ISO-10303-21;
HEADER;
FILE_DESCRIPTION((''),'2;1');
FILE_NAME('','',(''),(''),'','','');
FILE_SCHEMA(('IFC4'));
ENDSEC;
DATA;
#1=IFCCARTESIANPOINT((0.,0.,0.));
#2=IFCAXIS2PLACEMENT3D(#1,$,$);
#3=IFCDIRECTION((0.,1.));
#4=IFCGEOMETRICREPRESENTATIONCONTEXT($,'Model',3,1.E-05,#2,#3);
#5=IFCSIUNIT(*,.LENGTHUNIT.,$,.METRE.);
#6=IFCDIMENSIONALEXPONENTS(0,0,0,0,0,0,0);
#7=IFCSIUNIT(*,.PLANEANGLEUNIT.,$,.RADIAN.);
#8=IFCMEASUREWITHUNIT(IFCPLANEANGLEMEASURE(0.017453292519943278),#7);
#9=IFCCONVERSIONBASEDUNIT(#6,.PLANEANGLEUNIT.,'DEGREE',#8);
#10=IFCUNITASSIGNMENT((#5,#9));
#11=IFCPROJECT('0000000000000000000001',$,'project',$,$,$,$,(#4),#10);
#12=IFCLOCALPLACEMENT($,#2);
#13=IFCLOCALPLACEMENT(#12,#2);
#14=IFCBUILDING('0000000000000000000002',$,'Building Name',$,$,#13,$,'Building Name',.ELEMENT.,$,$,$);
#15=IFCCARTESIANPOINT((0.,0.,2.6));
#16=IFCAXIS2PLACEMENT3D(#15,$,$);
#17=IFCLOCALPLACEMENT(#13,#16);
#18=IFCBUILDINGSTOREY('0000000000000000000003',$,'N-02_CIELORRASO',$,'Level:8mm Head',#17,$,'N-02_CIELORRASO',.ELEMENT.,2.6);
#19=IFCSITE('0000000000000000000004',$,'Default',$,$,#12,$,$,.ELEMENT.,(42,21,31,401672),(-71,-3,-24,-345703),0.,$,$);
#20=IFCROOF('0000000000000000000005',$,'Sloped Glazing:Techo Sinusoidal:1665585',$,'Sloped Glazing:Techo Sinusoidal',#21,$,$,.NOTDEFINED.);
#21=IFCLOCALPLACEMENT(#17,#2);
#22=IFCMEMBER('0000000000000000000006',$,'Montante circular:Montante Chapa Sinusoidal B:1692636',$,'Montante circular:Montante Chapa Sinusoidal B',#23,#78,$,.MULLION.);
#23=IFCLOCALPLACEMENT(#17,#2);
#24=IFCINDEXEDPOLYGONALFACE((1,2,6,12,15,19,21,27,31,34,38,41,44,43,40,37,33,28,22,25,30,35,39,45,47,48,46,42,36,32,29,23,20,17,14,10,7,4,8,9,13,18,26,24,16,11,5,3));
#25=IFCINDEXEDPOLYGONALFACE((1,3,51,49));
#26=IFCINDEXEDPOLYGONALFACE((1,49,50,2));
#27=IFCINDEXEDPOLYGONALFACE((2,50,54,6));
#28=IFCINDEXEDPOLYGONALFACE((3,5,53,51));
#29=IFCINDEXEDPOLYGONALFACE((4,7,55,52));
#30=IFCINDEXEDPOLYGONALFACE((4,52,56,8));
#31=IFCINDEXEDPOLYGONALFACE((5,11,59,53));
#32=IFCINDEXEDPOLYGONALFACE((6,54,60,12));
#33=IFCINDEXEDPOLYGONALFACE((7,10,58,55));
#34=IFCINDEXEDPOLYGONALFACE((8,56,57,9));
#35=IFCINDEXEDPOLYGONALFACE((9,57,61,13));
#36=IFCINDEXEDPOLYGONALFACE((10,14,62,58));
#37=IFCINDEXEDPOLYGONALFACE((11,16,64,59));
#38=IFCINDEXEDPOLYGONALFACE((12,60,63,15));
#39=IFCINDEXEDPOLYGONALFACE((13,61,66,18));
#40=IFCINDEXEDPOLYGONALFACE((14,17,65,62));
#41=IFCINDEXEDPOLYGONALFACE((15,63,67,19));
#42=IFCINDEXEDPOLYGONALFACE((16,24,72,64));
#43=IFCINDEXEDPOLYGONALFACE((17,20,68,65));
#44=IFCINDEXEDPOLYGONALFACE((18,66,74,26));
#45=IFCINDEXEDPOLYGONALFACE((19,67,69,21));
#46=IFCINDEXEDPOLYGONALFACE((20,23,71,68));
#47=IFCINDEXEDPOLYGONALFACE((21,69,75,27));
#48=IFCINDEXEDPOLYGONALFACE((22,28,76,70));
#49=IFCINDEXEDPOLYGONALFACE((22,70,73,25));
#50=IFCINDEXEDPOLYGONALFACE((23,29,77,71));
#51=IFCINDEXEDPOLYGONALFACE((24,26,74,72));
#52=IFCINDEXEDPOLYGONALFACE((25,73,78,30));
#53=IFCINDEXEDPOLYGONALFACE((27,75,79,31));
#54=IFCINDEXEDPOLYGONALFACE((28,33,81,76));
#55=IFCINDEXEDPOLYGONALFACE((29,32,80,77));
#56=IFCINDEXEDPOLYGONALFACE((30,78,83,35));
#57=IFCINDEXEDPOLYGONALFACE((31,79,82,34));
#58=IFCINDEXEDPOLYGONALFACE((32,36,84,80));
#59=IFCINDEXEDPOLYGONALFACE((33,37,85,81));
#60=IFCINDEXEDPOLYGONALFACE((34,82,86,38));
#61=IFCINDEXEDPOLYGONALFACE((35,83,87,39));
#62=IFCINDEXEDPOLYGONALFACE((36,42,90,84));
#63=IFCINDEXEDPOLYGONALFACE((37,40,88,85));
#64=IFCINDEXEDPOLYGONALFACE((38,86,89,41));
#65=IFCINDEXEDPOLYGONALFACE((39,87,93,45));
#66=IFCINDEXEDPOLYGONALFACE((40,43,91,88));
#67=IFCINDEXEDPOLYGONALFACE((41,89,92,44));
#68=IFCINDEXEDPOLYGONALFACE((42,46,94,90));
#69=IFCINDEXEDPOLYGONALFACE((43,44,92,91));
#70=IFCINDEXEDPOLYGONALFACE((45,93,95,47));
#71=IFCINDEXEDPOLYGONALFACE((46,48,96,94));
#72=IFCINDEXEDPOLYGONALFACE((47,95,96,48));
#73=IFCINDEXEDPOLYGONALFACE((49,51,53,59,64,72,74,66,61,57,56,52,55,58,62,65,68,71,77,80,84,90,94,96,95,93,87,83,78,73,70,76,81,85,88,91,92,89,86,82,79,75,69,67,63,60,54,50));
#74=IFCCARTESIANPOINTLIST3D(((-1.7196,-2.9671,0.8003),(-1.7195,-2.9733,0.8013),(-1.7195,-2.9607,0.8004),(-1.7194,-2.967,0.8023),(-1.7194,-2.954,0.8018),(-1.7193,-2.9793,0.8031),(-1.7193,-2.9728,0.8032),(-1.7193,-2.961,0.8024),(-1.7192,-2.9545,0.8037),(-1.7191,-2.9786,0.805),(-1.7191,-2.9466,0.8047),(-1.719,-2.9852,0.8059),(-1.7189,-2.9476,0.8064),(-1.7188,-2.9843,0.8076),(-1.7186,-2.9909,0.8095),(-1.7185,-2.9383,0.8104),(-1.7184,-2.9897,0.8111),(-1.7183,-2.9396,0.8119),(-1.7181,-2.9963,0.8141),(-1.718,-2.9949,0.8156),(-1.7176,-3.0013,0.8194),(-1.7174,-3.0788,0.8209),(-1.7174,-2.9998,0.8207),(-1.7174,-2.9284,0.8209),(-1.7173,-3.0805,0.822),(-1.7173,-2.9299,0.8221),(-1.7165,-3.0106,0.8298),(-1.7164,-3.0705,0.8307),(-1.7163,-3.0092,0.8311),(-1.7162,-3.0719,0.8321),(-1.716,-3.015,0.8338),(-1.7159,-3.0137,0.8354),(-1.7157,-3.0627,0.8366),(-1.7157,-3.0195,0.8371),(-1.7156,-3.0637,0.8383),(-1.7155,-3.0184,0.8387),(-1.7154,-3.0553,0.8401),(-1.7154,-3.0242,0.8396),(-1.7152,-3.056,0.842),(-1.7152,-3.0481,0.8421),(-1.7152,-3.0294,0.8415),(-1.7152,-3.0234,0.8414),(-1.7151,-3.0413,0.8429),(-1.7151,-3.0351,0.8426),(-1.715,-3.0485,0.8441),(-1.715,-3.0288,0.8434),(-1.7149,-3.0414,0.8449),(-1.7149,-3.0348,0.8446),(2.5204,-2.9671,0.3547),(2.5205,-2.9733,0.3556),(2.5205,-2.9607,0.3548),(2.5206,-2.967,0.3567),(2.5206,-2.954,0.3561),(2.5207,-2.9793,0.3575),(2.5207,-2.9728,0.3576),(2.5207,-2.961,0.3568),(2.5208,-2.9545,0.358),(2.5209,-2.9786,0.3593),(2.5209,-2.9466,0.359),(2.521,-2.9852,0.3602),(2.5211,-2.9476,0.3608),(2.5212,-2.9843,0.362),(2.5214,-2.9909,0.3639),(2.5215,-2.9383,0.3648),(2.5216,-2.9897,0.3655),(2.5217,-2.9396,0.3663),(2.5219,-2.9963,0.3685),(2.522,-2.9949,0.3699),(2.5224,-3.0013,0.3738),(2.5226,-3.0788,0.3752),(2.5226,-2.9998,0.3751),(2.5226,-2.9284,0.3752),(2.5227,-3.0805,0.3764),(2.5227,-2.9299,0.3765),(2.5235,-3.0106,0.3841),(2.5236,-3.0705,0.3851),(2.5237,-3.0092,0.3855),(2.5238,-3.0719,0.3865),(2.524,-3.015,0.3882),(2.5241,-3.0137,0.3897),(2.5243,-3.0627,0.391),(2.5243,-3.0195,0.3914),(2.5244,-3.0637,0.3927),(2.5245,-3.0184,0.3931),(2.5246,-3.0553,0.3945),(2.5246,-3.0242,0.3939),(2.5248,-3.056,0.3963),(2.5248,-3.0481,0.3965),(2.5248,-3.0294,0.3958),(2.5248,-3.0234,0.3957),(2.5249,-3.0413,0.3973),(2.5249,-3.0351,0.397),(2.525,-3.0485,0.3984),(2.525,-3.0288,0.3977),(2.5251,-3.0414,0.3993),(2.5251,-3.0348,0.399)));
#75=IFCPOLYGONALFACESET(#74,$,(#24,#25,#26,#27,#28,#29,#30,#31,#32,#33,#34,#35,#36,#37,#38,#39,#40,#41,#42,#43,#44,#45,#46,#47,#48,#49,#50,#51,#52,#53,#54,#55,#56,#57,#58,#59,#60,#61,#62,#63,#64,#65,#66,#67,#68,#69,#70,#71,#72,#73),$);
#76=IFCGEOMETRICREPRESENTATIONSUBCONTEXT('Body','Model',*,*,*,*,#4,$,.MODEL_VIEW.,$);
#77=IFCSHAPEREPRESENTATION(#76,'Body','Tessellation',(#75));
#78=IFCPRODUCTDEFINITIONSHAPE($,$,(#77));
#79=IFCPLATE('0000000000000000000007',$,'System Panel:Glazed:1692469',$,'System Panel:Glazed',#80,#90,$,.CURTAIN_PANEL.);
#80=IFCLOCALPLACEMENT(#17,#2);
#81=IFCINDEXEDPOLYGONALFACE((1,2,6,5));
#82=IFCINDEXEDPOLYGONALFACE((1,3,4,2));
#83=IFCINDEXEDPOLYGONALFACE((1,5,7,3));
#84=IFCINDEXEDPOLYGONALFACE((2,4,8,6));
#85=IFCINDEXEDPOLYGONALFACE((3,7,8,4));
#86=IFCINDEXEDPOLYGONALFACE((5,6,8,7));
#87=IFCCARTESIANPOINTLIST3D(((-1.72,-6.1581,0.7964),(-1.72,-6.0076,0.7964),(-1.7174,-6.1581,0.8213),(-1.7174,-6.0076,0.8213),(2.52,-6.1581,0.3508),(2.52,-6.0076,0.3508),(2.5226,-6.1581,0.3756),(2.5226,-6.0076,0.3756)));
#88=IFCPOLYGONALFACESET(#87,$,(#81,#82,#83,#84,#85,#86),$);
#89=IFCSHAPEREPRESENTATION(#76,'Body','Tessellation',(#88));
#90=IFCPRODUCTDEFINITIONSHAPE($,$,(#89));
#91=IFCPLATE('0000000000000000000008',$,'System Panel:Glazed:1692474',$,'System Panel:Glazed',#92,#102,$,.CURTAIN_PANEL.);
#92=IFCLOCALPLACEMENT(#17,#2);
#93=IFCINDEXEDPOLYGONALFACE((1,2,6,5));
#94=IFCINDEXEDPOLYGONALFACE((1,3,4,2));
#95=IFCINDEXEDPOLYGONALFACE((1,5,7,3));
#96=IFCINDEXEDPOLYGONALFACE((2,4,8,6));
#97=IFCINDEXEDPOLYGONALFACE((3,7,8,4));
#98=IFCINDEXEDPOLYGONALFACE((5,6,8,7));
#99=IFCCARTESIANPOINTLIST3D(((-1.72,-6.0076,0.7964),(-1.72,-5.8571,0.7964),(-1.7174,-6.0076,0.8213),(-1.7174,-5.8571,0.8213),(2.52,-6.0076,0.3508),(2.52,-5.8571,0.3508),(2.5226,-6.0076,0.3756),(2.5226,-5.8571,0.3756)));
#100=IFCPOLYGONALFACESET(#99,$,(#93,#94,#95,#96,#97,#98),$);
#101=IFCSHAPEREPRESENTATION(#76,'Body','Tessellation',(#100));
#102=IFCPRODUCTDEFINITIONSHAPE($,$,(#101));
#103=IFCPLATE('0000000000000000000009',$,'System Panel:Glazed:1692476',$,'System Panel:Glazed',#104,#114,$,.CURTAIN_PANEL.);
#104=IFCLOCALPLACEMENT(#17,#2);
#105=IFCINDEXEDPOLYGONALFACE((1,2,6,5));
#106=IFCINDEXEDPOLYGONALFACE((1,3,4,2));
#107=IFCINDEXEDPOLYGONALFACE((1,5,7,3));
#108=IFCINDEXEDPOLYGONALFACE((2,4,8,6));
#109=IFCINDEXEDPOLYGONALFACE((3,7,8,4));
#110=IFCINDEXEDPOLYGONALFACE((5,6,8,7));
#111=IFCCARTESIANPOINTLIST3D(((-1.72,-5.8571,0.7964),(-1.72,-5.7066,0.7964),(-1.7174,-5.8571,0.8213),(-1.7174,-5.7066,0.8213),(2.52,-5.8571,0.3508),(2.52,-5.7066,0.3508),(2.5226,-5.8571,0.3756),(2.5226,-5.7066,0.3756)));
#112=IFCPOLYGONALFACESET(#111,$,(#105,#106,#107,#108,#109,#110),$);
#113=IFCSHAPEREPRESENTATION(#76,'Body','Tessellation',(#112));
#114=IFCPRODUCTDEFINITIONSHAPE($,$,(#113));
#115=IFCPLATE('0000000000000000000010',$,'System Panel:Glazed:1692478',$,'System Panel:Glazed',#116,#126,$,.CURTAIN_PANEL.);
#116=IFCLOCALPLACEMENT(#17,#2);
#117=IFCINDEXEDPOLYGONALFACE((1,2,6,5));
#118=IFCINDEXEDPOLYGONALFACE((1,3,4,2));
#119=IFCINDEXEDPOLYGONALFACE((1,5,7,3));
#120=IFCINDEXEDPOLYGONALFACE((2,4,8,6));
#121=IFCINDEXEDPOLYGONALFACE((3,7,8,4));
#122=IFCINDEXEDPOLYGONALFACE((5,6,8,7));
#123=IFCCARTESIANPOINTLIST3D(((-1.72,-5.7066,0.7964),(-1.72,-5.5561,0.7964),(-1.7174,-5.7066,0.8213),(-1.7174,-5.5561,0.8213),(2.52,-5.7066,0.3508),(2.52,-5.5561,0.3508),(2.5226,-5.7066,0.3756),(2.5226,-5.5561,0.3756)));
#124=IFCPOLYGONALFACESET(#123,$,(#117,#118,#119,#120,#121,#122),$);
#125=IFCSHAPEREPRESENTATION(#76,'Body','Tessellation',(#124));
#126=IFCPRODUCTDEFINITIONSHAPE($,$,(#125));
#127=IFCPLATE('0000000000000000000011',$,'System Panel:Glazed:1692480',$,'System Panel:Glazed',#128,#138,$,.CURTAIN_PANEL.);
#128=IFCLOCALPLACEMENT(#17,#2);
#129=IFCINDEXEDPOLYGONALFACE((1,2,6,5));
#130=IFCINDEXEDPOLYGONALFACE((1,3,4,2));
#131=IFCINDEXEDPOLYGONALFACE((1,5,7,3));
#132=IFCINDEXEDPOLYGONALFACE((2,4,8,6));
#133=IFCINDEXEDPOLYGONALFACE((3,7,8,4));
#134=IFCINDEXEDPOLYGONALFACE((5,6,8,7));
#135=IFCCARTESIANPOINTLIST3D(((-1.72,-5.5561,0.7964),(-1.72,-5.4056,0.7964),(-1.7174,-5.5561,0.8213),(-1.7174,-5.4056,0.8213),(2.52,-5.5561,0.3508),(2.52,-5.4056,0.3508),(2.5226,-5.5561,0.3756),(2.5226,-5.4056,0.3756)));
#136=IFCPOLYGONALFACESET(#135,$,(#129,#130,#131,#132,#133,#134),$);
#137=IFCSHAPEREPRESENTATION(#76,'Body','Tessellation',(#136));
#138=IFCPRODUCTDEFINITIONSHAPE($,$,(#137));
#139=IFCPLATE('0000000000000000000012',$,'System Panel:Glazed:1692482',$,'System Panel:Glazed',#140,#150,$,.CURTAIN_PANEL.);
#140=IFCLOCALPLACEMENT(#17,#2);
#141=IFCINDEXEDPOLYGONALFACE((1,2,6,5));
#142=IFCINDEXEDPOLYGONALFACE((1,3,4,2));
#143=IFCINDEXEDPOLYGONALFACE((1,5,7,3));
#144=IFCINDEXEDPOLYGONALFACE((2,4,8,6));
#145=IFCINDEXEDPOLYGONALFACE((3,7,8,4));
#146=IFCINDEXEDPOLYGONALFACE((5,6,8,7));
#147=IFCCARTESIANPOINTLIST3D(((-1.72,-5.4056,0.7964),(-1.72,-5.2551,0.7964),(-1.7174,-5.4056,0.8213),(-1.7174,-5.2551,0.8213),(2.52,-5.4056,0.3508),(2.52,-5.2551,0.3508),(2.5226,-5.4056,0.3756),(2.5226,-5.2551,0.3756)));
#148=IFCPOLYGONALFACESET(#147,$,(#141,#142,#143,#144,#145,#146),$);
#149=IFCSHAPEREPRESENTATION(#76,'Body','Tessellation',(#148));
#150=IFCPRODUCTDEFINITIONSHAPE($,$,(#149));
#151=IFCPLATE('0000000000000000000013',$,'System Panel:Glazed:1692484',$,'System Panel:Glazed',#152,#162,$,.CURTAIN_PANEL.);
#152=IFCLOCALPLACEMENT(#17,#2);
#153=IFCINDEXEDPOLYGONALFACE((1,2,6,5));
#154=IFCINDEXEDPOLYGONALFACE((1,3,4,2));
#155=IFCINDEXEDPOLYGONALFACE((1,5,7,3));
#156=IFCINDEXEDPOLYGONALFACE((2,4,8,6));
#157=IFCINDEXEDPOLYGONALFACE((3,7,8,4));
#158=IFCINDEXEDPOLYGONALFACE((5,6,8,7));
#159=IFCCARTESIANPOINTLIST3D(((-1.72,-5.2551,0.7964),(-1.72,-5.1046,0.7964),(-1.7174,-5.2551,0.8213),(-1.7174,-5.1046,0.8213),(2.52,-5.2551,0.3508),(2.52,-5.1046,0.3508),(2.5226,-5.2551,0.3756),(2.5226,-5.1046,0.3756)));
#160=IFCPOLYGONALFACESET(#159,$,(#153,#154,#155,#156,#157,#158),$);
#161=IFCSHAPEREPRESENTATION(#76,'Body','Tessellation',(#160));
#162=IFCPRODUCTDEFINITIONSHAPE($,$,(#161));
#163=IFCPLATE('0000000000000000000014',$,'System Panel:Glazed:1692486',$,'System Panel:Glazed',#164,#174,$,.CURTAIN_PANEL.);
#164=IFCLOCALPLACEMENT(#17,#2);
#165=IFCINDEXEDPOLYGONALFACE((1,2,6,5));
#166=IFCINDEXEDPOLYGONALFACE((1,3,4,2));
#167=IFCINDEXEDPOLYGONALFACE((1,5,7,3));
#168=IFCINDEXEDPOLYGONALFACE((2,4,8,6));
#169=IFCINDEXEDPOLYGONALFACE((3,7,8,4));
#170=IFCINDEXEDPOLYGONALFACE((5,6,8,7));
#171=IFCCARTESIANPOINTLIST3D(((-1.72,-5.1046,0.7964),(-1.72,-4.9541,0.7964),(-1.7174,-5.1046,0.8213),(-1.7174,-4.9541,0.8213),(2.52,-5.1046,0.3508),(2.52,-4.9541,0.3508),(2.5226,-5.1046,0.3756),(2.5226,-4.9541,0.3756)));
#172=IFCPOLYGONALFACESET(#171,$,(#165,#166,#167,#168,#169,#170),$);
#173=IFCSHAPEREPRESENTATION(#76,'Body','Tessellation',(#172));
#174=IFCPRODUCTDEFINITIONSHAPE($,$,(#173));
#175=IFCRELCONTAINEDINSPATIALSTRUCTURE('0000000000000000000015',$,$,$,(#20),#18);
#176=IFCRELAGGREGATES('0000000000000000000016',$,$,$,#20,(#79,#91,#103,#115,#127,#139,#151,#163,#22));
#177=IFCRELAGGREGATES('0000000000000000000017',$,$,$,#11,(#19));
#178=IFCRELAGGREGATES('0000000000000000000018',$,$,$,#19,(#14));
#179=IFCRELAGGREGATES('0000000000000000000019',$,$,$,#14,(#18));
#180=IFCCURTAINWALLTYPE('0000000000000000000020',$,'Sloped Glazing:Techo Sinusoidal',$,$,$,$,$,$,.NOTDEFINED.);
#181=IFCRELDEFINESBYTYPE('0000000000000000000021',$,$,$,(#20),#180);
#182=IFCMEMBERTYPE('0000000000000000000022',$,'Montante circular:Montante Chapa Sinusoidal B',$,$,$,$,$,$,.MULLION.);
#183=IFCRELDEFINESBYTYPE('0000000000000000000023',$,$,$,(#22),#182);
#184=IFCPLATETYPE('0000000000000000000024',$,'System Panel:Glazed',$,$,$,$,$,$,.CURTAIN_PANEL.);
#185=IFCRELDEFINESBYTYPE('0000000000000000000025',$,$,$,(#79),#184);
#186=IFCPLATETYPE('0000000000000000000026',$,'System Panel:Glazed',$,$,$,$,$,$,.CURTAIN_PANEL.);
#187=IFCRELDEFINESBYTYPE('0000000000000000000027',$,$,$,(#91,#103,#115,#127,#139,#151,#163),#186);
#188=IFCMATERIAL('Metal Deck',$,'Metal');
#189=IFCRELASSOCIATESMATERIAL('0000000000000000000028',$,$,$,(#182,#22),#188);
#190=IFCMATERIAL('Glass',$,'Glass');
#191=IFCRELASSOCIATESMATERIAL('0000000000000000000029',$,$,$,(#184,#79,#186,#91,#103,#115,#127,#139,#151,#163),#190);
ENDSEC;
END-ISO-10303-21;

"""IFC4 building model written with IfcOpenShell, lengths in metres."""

from ifc_helpers import new_model, entity, si_unit, converted_unit, direction, frame, origin, place, context, subcontext, project, spatial, indexed_curve, outline, extrude, source, transform, mapped, material, type_object, type_shapes, element, aggregate, save


model = new_model("IFC4")

# Units and contexts
model_context = context("Model", 3, precision=1e-05, world=origin(), true_north=direction((0.0, 1.0)))
body_context = subcontext(model_context, "Body", "Model", "MODEL_VIEW")
ifc_project = project(units=[si_unit("LENGTHUNIT", "METRE"), converted_unit("PLANEANGLEUNIT", "DEGREE", entity("IfcPlaneAngleMeasure", 0.017453292519943278), si_unit("PLANEANGLEUNIT", "RADIAN"), dimensions=[0, 0, 0, 0, 0, 0, 0])], contexts=[model_context])

# Site, building, storey
site_placement = place(None, origin())
site = spatial("IfcSite", under=ifc_project, at=site_placement, Name="Default", CompositionType="ELEMENT", RefLatitude=(42, 21, 31, 401672), RefLongitude=(-71, -3, -24, -345703), RefElevation=0.0)
building_placement = place(site_placement, origin())
building = spatial("IfcBuilding", under=site, at=building_placement, Name="Building Name", LongName="Building Name", CompositionType="ELEMENT")
storey_placement = place(building_placement, frame((0.0, 0.0, 2.6)))
storey = spatial("IfcBuildingStorey", under=building, at=storey_placement, Name="N-02_CIELORRASO", ObjectType="Level:8mm Head", LongName="N-02_CIELORRASO", CompositionType="ELEMENT", Elevation=2.6)

# Roof, member, plates
curtain_wall_type = type_object("IfcCurtainWallType", Name="Sloped Glazing:Techo Sinusoidal", PredefinedType="NOTDEFINED")
roof_placement = place(storey_placement, frame((0.0, 0.0, -2.6)))
roof = element("IfcRoof", 1, at=roof_placement, inside=storey, type_object=curtain_wall_type, Name="Sloped Glazing:Techo Sinusoidal:1665585", ObjectType="Sloped Glazing:Techo Sinusoidal", PredefinedType="NOTDEFINED")
ifc_material_1 = material(Name="Metal Deck", Category="Metal")
member_type = type_object("IfcMemberType", Name="Montante circular:Montante Chapa Sinusoidal B", PredefinedType="MULLION", material=ifc_material_1)
shared_shape_1 = source(origin(), body_context, "Body", "SweptSolid", [
    extrude(outline(indexed_curve([(0.0595, -0.0443), (0.0615, -0.0443), (0.0603, -0.031), (0.0572, -0.0213), (0.053, -0.0138), (0.0481, -0.0078), (0.0427, -0.003), (0.0372, 0.0005), (0.0315, 0.0029), (0.0259, 0.0044), (0.0203, 0.0051), (0.0146, 0.005), (0.0084, 0.0041), (-0.0053, 0.0009), (-0.0123, -0.0005), (-0.0191, -0.0012), (-0.0256, -0.001), (-0.0317, 0.0001), (-0.0375, 0.0019), (-0.0428, 0.0046), (-0.0477, 0.0081), (-0.0522, 0.0128), (-0.0563, 0.0191), (-0.0597, 0.0282), (-0.0617, 0.0421), (-0.0637, 0.042), (-0.0616, 0.0277), (-0.0581, 0.0182), (-0.0537, 0.0116), (-0.049, 0.0066), (-0.0438, 0.0028), (-0.0382, 0.0001), (-0.0322, -0.0019), (-0.0258, -0.003), (-0.019, -0.0032), (-0.012, -0.0025), (-0.0048, -0.0011), (0.0088, 0.0021), (0.0147, 0.003), (0.0202, 0.0031), (0.0255, 0.0024), (0.0309, 0.001), (0.0362, -0.0013), (0.0415, -0.0046), (0.0466, -0.0092), (0.0513, -0.0149), (0.0554, -0.0221), (0.0584, -0.0314), (0.0595, -0.0443)], self_intersect=False)), frame((-0.007, 0.0228, -4.2634), z_axis=(0.0, 0.0, 1.0), x_axis=(-0.819152, -0.573576, 0.0)), (0.0, 0.0, 1.0), 4.2634),
])
type_shapes(member_type, [shared_shape_1])
member_placement = place(roof_placement, frame((-1.7148, -2.9976, 3.4456), z_axis=(-0.994522, 0.0, 0.104528), x_axis=(0.0, 1.0, 0.0)))
member = element("IfcMember", 2, at=member_placement, type_object=member_type, material=ifc_material_1, Name="Montante circular:Montante Chapa Sinusoidal B:1692636", ObjectType="Montante circular:Montante Chapa Sinusoidal B", PredefinedType="MULLION", context=body_context, shape_type="MappedRepresentation", body=[
    mapped(shared_shape_1, transform((0.0, 0.0, 0.0), scale=1.0)),
])
ifc_material_2 = material(Name="Glass", Category="Glass")
plate_type_1 = type_object("IfcPlateType", Name="System Panel:Glazed", PredefinedType="CURTAIN_PANEL", material=ifc_material_2)
shared_shape_2 = source(origin(), body_context, "Body", "SweptSolid", [
    extrude(outline(indexed_curve([(-0.0125, -0.0753), (0.0125, -0.0753), (0.0125, 0.0753), (-0.0125, 0.0753), (-0.0125, -0.0753)], self_intersect=False)), frame((0.0, 0.037, 0.0), z_axis=(0.0, 0.0, 1.0), x_axis=(0.0, 1.0, 0.0)), (0.0, 0.0, 1.0), 4.2634),
])
type_shapes(plate_type_1, [shared_shape_2])
plate_1_placement = place(roof_placement, frame((2.5252, -6.0829, 3.0), z_axis=(-0.994522, 0.0, 0.104528), x_axis=(0.0, 1.0, 0.0)))
plate_1 = element("IfcPlate", 3, at=plate_1_placement, type_object=plate_type_1, material=ifc_material_2, Name="System Panel:Glazed:1692469", ObjectType="System Panel:Glazed", PredefinedType="CURTAIN_PANEL", context=body_context, shape_type="MappedRepresentation", body=[
    mapped(shared_shape_2, transform((0.0, 0.0, 0.0), scale=1.0)),
])
plate_type_2 = type_object("IfcPlateType", Name="System Panel:Glazed", PredefinedType="CURTAIN_PANEL", material=ifc_material_2)
shared_shape_3 = source(origin(), body_context, "Body", "SweptSolid", [
    extrude(outline(indexed_curve([(-0.0125, -0.0752), (0.0125, -0.0752), (0.0125, 0.0752), (-0.0125, 0.0752), (-0.0125, -0.0752)], self_intersect=False)), frame((0.0, 0.037, 0.0), z_axis=(0.0, 0.0, 1.0), x_axis=(0.0, 1.0, 0.0)), (0.0, 0.0, 1.0), 4.2634),
])
type_shapes(plate_type_2, [shared_shape_3])
plate_2_placement = place(roof_placement, frame((2.5252, -5.9324, 3.0), z_axis=(-0.994522, 0.0, 0.104528), x_axis=(0.0, 1.0, 0.0)))
plate_2 = element("IfcPlate", 4, at=plate_2_placement, type_object=plate_type_2, material=ifc_material_2, Name="System Panel:Glazed:1692474", ObjectType="System Panel:Glazed", PredefinedType="CURTAIN_PANEL", context=body_context, shape_type="MappedRepresentation", body=[
    mapped(shared_shape_3, transform((0.0, 0.0, 0.0), scale=1.0)),
])
plate_3_placement = place(roof_placement, frame((2.5252, -5.7819, 3.0), z_axis=(-0.994522, 0.0, 0.104528), x_axis=(0.0, 1.0, 0.0)))
plate_3 = element("IfcPlate", 5, at=plate_3_placement, type_object=plate_type_2, material=ifc_material_2, Name="System Panel:Glazed:1692476", ObjectType="System Panel:Glazed", PredefinedType="CURTAIN_PANEL", context=body_context, shape_type="MappedRepresentation", body=[
    mapped(shared_shape_3, transform((0.0, 0.0, 0.0), scale=1.0)),
])
plate_4_placement = place(roof_placement, frame((2.5252, -5.6314, 3.0), z_axis=(-0.994522, 0.0, 0.104528), x_axis=(0.0, 1.0, 0.0)))
plate_4 = element("IfcPlate", 6, at=plate_4_placement, type_object=plate_type_2, material=ifc_material_2, Name="System Panel:Glazed:1692478", ObjectType="System Panel:Glazed", PredefinedType="CURTAIN_PANEL", context=body_context, shape_type="MappedRepresentation", body=[
    mapped(shared_shape_3, transform((0.0, 0.0, 0.0), scale=1.0)),
])
plate_5_placement = place(roof_placement, frame((2.5252, -5.4809, 3.0), z_axis=(-0.994522, 0.0, 0.104528), x_axis=(0.0, 1.0, 0.0)))
plate_5 = element("IfcPlate", 7, at=plate_5_placement, type_object=plate_type_2, material=ifc_material_2, Name="System Panel:Glazed:1692480", ObjectType="System Panel:Glazed", PredefinedType="CURTAIN_PANEL", context=body_context, shape_type="MappedRepresentation", body=[
    mapped(shared_shape_3, transform((0.0, 0.0, 0.0), scale=1.0)),
])
plate_6_placement = place(roof_placement, frame((2.5252, -5.3304, 3.0), z_axis=(-0.994522, 0.0, 0.104528), x_axis=(0.0, 1.0, 0.0)))
plate_6 = element("IfcPlate", 8, at=plate_6_placement, type_object=plate_type_2, material=ifc_material_2, Name="System Panel:Glazed:1692482", ObjectType="System Panel:Glazed", PredefinedType="CURTAIN_PANEL", context=body_context, shape_type="MappedRepresentation", body=[
    mapped(shared_shape_3, transform((0.0, 0.0, 0.0), scale=1.0)),
])
plate_7_placement = place(roof_placement, frame((2.5252, -5.1799, 3.0), z_axis=(-0.994522, 0.0, 0.104528), x_axis=(0.0, 1.0, 0.0)))
plate_7 = element("IfcPlate", 9, at=plate_7_placement, type_object=plate_type_2, material=ifc_material_2, Name="System Panel:Glazed:1692484", ObjectType="System Panel:Glazed", PredefinedType="CURTAIN_PANEL", context=body_context, shape_type="MappedRepresentation", body=[
    mapped(shared_shape_3, transform((0.0, 0.0, 0.0), scale=1.0)),
])
plate_8_placement = place(roof_placement, frame((2.5252, -5.0294, 3.0), z_axis=(-0.994522, 0.0, 0.104528), x_axis=(0.0, 1.0, 0.0)))
plate_8 = element("IfcPlate", 10, at=plate_8_placement, type_object=plate_type_2, material=ifc_material_2, Name="System Panel:Glazed:1692486", ObjectType="System Panel:Glazed", PredefinedType="CURTAIN_PANEL", context=body_context, shape_type="MappedRepresentation", body=[
    mapped(shared_shape_3, transform((0.0, 0.0, 0.0), scale=1.0)),
])
aggregate(roof, [plate_1, plate_2, plate_3, plate_4, plate_5, plate_6, plate_7, plate_8, member])

save(model, "model.ifc")
